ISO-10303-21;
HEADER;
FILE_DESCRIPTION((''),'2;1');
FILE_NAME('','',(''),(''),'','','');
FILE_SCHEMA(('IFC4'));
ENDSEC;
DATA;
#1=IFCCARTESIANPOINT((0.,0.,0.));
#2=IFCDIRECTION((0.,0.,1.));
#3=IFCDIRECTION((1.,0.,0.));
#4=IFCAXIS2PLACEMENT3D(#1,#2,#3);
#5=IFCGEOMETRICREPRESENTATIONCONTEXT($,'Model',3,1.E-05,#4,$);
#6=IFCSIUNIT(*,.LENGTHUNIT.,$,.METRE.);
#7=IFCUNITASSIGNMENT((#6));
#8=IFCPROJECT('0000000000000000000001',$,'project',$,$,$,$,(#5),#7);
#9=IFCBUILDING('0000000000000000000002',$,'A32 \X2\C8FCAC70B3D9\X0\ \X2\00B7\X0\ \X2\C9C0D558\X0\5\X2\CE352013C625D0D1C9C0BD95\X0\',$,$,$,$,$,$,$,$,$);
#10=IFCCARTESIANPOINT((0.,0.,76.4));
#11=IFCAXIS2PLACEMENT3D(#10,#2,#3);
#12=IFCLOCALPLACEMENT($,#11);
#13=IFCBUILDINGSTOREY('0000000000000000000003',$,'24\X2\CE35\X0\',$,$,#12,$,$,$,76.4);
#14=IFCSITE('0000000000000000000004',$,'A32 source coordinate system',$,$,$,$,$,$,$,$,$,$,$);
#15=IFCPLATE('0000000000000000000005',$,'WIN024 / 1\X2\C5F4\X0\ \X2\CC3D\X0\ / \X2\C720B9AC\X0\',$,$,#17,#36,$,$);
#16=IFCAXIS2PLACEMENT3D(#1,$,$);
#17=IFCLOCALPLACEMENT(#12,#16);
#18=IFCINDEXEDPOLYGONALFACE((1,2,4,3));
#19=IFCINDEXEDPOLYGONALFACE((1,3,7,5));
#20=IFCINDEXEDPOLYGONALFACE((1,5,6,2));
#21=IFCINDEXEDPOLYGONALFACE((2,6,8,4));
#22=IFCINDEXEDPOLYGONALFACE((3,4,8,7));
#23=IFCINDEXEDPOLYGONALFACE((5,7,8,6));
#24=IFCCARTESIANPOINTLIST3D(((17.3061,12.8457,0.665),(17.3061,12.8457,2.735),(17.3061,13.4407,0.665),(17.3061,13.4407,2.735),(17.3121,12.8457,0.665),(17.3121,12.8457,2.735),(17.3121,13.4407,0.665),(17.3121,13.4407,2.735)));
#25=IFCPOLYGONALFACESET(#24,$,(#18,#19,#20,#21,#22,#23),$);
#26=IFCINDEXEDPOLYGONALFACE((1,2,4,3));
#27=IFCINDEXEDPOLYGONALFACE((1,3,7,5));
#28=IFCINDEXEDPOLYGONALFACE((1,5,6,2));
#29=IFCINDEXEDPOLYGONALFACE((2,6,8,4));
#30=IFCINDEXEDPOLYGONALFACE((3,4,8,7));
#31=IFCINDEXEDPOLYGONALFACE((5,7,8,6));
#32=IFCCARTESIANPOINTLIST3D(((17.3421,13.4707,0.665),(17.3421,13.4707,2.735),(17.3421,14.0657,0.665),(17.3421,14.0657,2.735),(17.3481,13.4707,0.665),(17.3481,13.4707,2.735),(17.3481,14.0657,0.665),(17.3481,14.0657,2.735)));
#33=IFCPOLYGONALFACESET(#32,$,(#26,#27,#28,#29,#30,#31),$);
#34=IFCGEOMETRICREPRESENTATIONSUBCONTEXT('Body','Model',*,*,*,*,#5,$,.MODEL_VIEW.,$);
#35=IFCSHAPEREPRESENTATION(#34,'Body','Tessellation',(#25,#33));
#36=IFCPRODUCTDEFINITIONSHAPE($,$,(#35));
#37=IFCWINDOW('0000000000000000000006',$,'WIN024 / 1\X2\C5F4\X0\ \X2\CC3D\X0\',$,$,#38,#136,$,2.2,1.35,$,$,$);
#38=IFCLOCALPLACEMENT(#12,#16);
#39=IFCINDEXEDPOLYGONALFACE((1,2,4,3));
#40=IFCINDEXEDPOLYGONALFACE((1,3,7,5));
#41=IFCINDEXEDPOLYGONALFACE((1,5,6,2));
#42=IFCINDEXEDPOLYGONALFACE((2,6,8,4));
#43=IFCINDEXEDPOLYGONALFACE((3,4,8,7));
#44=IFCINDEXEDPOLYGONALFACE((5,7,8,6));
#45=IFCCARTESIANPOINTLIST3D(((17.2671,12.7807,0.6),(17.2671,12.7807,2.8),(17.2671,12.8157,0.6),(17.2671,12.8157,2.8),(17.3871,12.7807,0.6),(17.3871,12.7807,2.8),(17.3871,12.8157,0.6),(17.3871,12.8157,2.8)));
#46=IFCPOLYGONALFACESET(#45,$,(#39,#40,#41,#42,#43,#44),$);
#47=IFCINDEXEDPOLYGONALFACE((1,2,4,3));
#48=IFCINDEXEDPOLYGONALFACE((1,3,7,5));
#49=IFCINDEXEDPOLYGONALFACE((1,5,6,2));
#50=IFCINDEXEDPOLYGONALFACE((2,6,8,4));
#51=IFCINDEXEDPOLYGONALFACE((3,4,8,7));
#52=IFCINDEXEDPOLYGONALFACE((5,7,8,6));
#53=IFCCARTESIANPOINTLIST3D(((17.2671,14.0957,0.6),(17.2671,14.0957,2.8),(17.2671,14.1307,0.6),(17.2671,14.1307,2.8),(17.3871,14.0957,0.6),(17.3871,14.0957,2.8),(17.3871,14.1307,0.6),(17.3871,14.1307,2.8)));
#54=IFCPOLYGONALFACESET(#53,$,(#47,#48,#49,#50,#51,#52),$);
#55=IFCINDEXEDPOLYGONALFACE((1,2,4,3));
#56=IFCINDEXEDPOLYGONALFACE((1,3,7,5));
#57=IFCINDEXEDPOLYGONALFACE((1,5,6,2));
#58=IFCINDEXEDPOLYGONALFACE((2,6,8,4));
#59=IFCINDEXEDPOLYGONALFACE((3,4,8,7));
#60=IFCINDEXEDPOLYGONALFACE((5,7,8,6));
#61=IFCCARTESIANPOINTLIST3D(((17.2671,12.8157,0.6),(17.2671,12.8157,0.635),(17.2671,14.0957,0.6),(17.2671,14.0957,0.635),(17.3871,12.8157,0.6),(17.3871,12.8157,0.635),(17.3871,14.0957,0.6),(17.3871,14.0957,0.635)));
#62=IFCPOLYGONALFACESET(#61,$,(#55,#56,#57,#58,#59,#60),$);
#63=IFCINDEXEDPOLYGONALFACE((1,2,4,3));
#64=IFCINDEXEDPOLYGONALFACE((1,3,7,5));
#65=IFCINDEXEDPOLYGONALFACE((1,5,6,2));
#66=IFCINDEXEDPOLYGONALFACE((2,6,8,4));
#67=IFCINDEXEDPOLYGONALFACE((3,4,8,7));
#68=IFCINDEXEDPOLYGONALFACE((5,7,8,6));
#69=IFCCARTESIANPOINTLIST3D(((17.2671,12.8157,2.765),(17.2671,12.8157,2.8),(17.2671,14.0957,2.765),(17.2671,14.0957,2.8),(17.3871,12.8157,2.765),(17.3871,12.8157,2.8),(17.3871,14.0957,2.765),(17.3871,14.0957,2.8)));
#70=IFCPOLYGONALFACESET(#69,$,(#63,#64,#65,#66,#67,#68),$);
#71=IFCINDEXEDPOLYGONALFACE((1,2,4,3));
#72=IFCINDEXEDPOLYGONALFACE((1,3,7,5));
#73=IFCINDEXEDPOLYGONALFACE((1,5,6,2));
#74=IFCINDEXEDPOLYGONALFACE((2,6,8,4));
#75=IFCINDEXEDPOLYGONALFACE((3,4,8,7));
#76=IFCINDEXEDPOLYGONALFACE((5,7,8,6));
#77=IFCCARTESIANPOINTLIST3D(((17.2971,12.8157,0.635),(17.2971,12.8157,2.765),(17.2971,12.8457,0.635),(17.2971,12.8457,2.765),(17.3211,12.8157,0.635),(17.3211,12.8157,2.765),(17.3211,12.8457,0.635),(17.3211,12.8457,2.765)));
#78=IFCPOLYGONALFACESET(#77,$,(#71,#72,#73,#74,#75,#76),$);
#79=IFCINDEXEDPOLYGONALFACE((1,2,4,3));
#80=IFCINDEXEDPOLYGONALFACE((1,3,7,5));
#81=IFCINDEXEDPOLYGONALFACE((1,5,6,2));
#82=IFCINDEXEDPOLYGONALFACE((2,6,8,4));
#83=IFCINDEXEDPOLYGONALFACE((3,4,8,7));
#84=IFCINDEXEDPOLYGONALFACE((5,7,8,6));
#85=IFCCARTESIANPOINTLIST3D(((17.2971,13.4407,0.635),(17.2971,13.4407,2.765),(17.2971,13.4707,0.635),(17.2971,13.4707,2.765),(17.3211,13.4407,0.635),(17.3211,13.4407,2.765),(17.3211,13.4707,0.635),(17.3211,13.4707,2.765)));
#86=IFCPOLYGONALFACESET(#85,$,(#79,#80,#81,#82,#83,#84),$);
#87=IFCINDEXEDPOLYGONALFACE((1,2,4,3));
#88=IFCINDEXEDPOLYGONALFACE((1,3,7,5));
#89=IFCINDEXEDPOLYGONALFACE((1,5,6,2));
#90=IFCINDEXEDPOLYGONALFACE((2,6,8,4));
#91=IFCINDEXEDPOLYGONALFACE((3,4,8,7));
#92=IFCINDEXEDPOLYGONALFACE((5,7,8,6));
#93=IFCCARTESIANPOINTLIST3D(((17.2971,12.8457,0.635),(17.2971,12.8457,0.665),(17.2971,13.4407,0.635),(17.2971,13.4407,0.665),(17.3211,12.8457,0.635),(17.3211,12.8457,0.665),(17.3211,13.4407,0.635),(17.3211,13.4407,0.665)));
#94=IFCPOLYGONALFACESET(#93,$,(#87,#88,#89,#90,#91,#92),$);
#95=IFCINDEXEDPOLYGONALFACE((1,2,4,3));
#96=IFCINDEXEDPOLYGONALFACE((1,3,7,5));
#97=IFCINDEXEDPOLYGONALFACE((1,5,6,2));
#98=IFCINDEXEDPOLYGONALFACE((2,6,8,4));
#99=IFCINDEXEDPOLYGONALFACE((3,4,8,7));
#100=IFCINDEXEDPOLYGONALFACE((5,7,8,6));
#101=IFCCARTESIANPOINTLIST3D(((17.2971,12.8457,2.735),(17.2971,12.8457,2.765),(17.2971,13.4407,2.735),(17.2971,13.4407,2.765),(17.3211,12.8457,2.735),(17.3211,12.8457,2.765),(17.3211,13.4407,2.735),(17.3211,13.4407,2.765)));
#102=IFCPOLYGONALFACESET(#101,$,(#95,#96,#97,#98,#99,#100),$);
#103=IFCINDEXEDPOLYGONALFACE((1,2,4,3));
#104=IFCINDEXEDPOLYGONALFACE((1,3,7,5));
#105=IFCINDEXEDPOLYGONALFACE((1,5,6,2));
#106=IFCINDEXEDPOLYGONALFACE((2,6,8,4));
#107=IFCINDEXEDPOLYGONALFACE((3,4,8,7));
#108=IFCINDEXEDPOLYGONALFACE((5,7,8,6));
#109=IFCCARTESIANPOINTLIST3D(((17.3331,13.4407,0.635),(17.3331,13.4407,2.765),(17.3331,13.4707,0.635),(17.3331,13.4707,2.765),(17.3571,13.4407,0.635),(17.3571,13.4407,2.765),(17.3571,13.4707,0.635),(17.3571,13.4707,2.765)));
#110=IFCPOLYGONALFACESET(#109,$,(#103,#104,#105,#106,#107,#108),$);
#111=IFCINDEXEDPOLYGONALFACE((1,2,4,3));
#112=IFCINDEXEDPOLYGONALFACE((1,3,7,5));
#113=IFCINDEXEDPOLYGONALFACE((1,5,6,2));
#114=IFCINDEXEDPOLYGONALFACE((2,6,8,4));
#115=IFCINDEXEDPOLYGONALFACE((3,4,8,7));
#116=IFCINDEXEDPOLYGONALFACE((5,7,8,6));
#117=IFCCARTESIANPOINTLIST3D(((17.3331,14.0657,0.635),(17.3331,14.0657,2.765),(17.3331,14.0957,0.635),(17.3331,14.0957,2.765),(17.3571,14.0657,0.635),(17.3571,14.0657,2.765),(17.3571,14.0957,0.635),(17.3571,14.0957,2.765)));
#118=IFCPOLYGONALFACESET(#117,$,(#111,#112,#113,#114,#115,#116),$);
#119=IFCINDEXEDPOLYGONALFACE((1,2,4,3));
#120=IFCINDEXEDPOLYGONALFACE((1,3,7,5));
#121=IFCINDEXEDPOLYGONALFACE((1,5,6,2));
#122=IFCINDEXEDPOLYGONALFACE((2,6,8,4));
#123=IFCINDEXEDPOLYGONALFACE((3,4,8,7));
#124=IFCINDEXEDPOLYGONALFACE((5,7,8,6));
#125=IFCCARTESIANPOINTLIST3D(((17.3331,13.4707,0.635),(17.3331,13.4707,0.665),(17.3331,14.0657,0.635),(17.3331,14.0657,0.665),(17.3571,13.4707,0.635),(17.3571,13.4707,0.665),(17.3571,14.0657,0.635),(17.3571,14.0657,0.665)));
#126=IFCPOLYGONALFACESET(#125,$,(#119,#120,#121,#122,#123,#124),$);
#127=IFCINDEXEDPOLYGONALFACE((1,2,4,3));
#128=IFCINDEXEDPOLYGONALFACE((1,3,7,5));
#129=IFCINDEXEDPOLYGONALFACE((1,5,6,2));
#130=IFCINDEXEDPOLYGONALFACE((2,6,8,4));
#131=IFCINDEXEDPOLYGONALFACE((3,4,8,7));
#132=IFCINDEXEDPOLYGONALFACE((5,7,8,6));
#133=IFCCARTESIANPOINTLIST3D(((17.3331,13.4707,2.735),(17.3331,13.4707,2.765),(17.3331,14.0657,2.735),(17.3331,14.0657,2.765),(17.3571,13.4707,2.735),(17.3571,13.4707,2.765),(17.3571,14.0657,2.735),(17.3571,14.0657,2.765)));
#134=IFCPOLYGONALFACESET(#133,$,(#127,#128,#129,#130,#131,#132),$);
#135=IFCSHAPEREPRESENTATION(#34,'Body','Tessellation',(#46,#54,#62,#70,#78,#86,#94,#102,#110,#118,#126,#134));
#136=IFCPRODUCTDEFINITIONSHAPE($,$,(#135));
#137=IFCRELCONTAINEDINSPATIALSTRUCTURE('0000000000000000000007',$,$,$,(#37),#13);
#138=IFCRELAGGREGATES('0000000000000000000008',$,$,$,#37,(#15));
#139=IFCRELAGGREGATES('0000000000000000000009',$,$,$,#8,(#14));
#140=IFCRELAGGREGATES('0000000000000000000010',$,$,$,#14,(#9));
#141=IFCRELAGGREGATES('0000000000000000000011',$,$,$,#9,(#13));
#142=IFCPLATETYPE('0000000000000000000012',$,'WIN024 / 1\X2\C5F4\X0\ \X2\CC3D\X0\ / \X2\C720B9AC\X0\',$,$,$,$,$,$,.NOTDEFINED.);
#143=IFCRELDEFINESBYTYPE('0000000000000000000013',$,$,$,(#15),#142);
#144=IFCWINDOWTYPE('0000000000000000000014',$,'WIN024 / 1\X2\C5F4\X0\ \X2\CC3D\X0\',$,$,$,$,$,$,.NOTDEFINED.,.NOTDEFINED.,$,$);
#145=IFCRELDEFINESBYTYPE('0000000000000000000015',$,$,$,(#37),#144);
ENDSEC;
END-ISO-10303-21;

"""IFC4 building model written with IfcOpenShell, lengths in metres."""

from ifc_helpers import new_model, si_unit, frame, origin, origin_with_axes, place, context, subcontext, project, spatial, polyline, outline, extrude, source, transform, mapped, type_object, type_shapes, element, aggregate, save


model = new_model("IFC4")

# Units and contexts
model_context = context("Model", 3, precision=1e-05, world=origin_with_axes())
body_context = subcontext(model_context, "Body", "Model", "MODEL_VIEW")
ifc_project = project(units=[si_unit("LENGTHUNIT", "METRE")], contexts=[model_context])

# Site, building, storey
site = spatial("IfcSite", under=ifc_project, Name="A32 source coordinate system")
building = spatial("IfcBuilding", under=site, Name="A32 주거동 · 지하5층–옥탑지붕")
storey_placement = place(None, frame((0.0, 0.0, 76.4), z_axis=(0.0, 0.0, 1.0), x_axis=(1.0, 0.0, 0.0)))
storey = spatial("IfcBuildingStorey", under=building, at=storey_placement, Name="24층", Elevation=76.4)

# Plate
plate_type_1 = type_object("IfcPlateType", Name="WIN024 / 1열 창 / 유리", PredefinedType="NOTDEFINED")
shared_shape_1 = source(origin(), body_context, "Body", "SweptSolid", [
    extrude(outline(polyline([(17.3061, 12.8457), (17.3061, 13.4407), (17.3121, 13.4407), (17.3121, 12.8457), (17.3061, 12.8457)])), frame((0.0, 0.0, 0.665)), (0.0, 0.0, 1.0), 2.07),
    extrude(outline(polyline([(17.3421, 13.4707), (17.3421, 14.0657), (17.3481, 14.0657), (17.3481, 13.4707), (17.3421, 13.4707)])), frame((0.0, 0.0, 0.665)), (0.0, 0.0, 1.0), 2.07),
])
type_shapes(plate_type_1, [shared_shape_1])
window_1_placement = place(storey_placement, origin_with_axes())
plate_1_placement = place(window_1_placement, origin_with_axes())
plate_1 = element("IfcPlate", 1, at=plate_1_placement, type_object=plate_type_1, Name="WIN024 / 1열 창 / 유리", context=body_context, shape_type="MappedRepresentation", body=[
    mapped(shared_shape_1, transform((0.0, 0.0, 0.0), scale=1.0)),
])

# Window
window_type_1 = type_object("IfcWindowType", Name="WIN024 / 1열 창", PartitioningType="NOTDEFINED", PredefinedType="NOTDEFINED")
shared_shape_2 = source(origin(), body_context, "Body", "SweptSolid", [
    extrude(outline(polyline([(17.2671, 12.7807), (17.2671, 12.8157), (17.3871, 12.8157), (17.3871, 12.7807), (17.2671, 12.7807)])), frame((0.0, 0.0, 0.6)), (0.0, 0.0, 1.0), 2.2),
    extrude(outline(polyline([(17.2671, 14.0957), (17.2671, 14.1307), (17.3871, 14.1307), (17.3871, 14.0957), (17.2671, 14.0957)])), frame((0.0, 0.0, 0.6)), (0.0, 0.0, 1.0), 2.2),
    extrude(outline(polyline([(17.2671, 12.8157), (17.2671, 14.0957), (17.3871, 14.0957), (17.3871, 12.8157), (17.2671, 12.8157)])), frame((0.0, 0.0, 0.6)), (0.0, 0.0, 1.0), 0.035),
    extrude(outline(polyline([(17.2671, 12.8157), (17.2671, 14.0957), (17.3871, 14.0957), (17.3871, 12.8157), (17.2671, 12.8157)])), frame((0.0, 0.0, 2.765)), (0.0, 0.0, 1.0), 0.035),
    extrude(outline(polyline([(17.2971, 12.8157), (17.2971, 12.8457), (17.3211, 12.8457), (17.3211, 12.8157), (17.2971, 12.8157)])), frame((0.0, 0.0, 0.635)), (0.0, 0.0, 1.0), 2.13),
    extrude(outline(polyline([(17.2971, 13.4407), (17.2971, 13.4707), (17.3211, 13.4707), (17.3211, 13.4407), (17.2971, 13.4407)])), frame((0.0, 0.0, 0.635)), (0.0, 0.0, 1.0), 2.13),
    extrude(outline(polyline([(17.2971, 12.8457), (17.2971, 13.4407), (17.3211, 13.4407), (17.3211, 12.8457), (17.2971, 12.8457)])), frame((0.0, 0.0, 0.635)), (0.0, 0.0, 1.0), 0.03),
    extrude(outline(polyline([(17.2971, 12.8457), (17.2971, 13.4407), (17.3211, 13.4407), (17.3211, 12.8457), (17.2971, 12.8457)])), frame((0.0, 0.0, 2.735)), (0.0, 0.0, 1.0), 0.03),
    extrude(outline(polyline([(17.3331, 13.4407), (17.3331, 13.4707), (17.3571, 13.4707), (17.3571, 13.4407), (17.3331, 13.4407)])), frame((0.0, 0.0, 0.635)), (0.0, 0.0, 1.0), 2.13),
    extrude(outline(polyline([(17.3331, 14.0657), (17.3331, 14.0957), (17.3571, 14.0957), (17.3571, 14.0657), (17.3331, 14.0657)])), frame((0.0, 0.0, 0.635)), (0.0, 0.0, 1.0), 2.13),
    extrude(outline(polyline([(17.3331, 13.4707), (17.3331, 14.0657), (17.3571, 14.0657), (17.3571, 13.4707), (17.3331, 13.4707)])), frame((0.0, 0.0, 0.635)), (0.0, 0.0, 1.0), 0.03),
    extrude(outline(polyline([(17.3331, 13.4707), (17.3331, 14.0657), (17.3571, 14.0657), (17.3571, 13.4707), (17.3331, 13.4707)])), frame((0.0, 0.0, 2.735)), (0.0, 0.0, 1.0), 0.03),
])
type_shapes(window_type_1, [shared_shape_2])
window_1 = element("IfcWindow", 2, at=window_1_placement, inside=storey, type_object=window_type_1, Name="WIN024 / 1열 창", OverallHeight=2.2, OverallWidth=1.35, context=body_context, shape_type="MappedRepresentation", body=[
    mapped(shared_shape_2, transform((0.0, 0.0, 0.0), scale=1.0)),
])
aggregate(window_1, [plate_1])

save(model, "model.ifc")
